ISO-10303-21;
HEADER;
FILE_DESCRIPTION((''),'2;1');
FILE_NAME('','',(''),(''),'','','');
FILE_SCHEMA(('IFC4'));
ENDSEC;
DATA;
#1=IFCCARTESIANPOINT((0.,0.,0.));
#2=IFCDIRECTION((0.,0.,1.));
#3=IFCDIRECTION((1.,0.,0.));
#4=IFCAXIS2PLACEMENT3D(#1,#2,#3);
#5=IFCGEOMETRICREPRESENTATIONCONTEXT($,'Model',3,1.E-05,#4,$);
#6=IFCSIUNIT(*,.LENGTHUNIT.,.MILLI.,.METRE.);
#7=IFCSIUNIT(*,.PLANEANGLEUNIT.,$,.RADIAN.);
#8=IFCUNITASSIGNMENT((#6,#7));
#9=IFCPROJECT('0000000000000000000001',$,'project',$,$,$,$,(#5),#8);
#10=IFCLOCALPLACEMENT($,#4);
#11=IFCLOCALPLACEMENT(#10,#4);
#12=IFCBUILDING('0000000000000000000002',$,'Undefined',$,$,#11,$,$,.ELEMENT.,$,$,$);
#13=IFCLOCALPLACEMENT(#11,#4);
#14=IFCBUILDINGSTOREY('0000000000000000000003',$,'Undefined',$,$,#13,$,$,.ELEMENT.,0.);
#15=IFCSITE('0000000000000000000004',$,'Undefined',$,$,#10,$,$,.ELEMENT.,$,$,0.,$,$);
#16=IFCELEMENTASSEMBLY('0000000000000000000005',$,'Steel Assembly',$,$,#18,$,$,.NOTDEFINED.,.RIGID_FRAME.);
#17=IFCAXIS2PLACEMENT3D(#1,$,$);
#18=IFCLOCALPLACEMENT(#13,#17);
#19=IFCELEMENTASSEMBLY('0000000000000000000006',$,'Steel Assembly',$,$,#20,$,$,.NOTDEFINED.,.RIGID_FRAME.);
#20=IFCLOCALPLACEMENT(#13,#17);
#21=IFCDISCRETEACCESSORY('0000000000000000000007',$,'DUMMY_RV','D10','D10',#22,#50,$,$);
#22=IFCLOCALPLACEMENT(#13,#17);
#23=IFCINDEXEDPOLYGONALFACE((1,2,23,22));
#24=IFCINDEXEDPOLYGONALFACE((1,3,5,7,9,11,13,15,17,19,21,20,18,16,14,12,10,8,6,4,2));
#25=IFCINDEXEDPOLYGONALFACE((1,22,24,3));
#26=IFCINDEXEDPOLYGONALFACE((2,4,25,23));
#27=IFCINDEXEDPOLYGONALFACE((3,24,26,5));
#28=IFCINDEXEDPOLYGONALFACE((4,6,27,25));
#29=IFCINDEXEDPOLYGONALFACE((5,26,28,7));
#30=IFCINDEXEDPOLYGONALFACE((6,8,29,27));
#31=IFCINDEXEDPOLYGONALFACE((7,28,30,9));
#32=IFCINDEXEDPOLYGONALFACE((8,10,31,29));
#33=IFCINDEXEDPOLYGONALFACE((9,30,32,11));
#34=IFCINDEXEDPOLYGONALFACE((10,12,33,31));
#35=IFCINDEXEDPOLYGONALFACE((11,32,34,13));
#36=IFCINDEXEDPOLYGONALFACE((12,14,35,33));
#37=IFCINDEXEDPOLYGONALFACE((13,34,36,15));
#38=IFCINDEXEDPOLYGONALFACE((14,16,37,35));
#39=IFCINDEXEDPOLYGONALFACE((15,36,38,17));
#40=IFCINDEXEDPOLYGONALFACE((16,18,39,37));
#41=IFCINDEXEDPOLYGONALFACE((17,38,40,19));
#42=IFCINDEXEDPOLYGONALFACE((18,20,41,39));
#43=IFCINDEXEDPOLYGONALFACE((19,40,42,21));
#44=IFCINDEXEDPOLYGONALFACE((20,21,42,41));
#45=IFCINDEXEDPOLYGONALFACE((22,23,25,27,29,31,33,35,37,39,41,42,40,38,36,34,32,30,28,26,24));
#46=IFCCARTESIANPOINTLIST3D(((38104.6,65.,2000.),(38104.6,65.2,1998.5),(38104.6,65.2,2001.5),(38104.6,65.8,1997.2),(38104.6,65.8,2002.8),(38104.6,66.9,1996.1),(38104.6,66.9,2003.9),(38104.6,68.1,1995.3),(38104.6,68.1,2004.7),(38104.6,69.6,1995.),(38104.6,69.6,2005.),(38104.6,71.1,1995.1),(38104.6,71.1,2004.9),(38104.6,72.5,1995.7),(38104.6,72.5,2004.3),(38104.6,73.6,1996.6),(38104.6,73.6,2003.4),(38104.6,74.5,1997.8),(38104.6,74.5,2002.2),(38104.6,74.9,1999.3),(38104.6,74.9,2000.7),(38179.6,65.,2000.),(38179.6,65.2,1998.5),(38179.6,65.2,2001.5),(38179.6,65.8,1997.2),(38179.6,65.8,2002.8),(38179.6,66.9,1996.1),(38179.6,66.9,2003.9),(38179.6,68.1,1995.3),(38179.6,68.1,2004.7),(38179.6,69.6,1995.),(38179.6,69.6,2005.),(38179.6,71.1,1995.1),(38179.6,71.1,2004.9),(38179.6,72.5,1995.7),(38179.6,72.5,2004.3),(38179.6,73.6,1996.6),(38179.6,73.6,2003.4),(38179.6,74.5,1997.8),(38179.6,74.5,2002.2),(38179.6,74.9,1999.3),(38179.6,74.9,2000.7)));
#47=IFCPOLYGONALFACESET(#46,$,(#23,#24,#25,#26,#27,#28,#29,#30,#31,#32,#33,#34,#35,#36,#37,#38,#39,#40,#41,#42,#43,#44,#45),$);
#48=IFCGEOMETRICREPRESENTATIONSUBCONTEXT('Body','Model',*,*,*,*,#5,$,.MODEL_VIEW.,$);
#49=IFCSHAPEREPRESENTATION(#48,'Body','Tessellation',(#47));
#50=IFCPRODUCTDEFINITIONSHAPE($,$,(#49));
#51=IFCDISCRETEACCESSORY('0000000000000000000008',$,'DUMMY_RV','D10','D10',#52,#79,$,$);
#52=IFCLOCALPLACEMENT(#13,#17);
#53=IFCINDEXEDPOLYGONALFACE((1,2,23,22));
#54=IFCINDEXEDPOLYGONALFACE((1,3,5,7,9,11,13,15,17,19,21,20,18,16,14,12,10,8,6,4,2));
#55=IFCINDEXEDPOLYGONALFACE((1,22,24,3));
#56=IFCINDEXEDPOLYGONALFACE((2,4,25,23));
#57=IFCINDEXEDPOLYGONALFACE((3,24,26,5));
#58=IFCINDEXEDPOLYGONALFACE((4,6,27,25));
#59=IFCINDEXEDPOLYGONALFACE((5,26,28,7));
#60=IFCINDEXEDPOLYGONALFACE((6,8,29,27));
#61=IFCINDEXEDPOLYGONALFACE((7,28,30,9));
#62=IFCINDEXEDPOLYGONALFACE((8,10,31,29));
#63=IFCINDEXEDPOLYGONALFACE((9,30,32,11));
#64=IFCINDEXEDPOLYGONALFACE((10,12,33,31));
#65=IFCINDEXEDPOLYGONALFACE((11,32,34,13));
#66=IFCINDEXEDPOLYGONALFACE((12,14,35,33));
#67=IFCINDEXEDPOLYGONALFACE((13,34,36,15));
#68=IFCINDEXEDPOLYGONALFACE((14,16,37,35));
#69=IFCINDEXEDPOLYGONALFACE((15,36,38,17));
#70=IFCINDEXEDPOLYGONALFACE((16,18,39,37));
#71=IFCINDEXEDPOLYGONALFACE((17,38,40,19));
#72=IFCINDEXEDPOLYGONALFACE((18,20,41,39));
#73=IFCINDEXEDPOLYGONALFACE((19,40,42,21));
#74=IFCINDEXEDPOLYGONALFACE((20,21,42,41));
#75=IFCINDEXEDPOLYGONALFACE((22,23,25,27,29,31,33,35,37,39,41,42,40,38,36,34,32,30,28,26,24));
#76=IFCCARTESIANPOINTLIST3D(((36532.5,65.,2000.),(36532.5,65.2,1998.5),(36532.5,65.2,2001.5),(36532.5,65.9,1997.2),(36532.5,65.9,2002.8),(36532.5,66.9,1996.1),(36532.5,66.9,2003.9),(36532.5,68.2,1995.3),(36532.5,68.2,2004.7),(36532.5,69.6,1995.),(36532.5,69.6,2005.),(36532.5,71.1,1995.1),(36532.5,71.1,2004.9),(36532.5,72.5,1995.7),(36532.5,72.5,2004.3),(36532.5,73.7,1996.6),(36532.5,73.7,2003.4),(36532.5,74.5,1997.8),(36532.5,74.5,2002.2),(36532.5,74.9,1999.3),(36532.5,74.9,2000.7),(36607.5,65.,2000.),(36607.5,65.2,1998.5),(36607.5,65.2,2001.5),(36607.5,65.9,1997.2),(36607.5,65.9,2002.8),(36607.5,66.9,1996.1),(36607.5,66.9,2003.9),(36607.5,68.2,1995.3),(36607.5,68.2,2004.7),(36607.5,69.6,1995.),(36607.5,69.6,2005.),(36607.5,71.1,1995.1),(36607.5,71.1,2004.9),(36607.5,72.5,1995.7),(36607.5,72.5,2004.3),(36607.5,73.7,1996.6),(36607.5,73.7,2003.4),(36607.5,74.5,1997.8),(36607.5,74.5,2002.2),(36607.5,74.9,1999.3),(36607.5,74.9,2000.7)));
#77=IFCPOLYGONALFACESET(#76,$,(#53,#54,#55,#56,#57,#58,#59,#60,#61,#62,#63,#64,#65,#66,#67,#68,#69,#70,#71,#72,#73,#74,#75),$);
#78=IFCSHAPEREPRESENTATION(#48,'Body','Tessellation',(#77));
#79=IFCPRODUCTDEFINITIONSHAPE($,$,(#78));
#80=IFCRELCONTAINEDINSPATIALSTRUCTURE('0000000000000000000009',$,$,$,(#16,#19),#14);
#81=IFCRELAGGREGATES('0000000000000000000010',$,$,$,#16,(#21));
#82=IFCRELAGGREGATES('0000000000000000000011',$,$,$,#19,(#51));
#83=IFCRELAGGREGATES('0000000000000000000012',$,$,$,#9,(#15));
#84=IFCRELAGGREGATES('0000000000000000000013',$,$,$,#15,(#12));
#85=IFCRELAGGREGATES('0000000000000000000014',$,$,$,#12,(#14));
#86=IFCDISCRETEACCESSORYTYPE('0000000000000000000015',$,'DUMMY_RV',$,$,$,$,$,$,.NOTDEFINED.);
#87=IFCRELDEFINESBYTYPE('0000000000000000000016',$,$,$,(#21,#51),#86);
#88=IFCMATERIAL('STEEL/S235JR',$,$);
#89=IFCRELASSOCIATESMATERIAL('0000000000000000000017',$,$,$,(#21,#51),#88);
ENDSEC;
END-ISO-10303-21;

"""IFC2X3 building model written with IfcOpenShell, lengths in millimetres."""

from ifc_helpers import new_model, si_unit, frame, frame_2d, origin_with_axes, place, context, subcontext, project, spatial, circle, extrude, material, type_object, element, aggregate, save


model = new_model("IFC2X3")

# Units and contexts
model_context = context("Model", 3, precision=1e-05, world=origin_with_axes())
body_context = subcontext(model_context, "Body", "Model", "MODEL_VIEW")
ifc_project = project(units=[si_unit("LENGTHUNIT", "METRE", prefix="MILLI"), si_unit("PLANEANGLEUNIT", "RADIAN")], contexts=[model_context])

# Site, building, storey
site_placement = place(None, origin_with_axes())
site = spatial("IfcSite", under=ifc_project, at=site_placement, Name="Undefined", CompositionType="ELEMENT", RefElevation=0.0)
building_placement = place(site_placement, origin_with_axes())
building = spatial("IfcBuilding", under=site, at=building_placement, Name="Undefined", CompositionType="ELEMENT")
storey_placement = place(building_placement, origin_with_axes())
storey = spatial("IfcBuildingStorey", under=building, at=storey_placement, Name="Undefined", CompositionType="ELEMENT", Elevation=0.0)

# Element assemblies
ifc_material_1 = material(Name="STEEL/S235JR")
assembly_1_placement = place(storey_placement, origin_with_axes())
assembly_1 = element("IfcElementAssembly", 1, at=assembly_1_placement, inside=storey, Name="Steel Assembly", AssemblyPlace="NOTDEFINED", PredefinedType="RIGID_FRAME")
assembly_2_placement = place(storey_placement, origin_with_axes())
assembly_2 = element("IfcElementAssembly", 2, at=assembly_2_placement, inside=storey, Name="Steel Assembly", AssemblyPlace="NOTDEFINED", PredefinedType="RIGID_FRAME")

# Discrete accessories
discrete_accessory_type = type_object("IfcDiscreteAccessoryType", Name="DUMMY_RV")
discrete_accessory_1_placement = place(assembly_1_placement, frame((38104.6, 70.0, 2000.0), z_axis=(0.0, 0.0, 1.0), x_axis=(1.0, -0.000007, 0.0)))
discrete_accessory_1 = element("IfcDiscreteAccessory", 3, at=discrete_accessory_1_placement, type_object=discrete_accessory_type, material=ifc_material_1, Name="DUMMY_RV", Description="D10", ObjectType="D10", context=body_context, shape_type="SweptSolid", body=[
    extrude(circle(Radius=5.0, at=frame_2d((0.0, 0.0), x_axis=(1.0, 0.0))), frame((75.0, 0.0, 0.0), z_axis=(-1.0, 0.0, 0.0), x_axis=(0.0, -1.0, 0.0)), (0.0, 0.0, 1.0), 75.0),
])
aggregate(assembly_1, [discrete_accessory_1])
discrete_accessory_2_placement = place(assembly_2_placement, frame((36532.5, 70.0, 2000.0), z_axis=(0.0, 0.0, 1.0), x_axis=(1.0, -0.000007, 0.0)))
discrete_accessory_2 = element("IfcDiscreteAccessory", 4, at=discrete_accessory_2_placement, type_object=discrete_accessory_type, material=ifc_material_1, Name="DUMMY_RV", Description="D10", ObjectType="D10", context=body_context, shape_type="SweptSolid", body=[
    extrude(circle(Radius=5.0, at=frame_2d((0.0, 0.0), x_axis=(1.0, 0.0))), frame((75.0, 0.0, 0.0), z_axis=(-1.0, 0.0, 0.0), x_axis=(0.0, -1.0, 0.0)), (0.0, 0.0, 1.0), 75.0),
])
aggregate(assembly_2, [discrete_accessory_2])

save(model, "model.ifc")
